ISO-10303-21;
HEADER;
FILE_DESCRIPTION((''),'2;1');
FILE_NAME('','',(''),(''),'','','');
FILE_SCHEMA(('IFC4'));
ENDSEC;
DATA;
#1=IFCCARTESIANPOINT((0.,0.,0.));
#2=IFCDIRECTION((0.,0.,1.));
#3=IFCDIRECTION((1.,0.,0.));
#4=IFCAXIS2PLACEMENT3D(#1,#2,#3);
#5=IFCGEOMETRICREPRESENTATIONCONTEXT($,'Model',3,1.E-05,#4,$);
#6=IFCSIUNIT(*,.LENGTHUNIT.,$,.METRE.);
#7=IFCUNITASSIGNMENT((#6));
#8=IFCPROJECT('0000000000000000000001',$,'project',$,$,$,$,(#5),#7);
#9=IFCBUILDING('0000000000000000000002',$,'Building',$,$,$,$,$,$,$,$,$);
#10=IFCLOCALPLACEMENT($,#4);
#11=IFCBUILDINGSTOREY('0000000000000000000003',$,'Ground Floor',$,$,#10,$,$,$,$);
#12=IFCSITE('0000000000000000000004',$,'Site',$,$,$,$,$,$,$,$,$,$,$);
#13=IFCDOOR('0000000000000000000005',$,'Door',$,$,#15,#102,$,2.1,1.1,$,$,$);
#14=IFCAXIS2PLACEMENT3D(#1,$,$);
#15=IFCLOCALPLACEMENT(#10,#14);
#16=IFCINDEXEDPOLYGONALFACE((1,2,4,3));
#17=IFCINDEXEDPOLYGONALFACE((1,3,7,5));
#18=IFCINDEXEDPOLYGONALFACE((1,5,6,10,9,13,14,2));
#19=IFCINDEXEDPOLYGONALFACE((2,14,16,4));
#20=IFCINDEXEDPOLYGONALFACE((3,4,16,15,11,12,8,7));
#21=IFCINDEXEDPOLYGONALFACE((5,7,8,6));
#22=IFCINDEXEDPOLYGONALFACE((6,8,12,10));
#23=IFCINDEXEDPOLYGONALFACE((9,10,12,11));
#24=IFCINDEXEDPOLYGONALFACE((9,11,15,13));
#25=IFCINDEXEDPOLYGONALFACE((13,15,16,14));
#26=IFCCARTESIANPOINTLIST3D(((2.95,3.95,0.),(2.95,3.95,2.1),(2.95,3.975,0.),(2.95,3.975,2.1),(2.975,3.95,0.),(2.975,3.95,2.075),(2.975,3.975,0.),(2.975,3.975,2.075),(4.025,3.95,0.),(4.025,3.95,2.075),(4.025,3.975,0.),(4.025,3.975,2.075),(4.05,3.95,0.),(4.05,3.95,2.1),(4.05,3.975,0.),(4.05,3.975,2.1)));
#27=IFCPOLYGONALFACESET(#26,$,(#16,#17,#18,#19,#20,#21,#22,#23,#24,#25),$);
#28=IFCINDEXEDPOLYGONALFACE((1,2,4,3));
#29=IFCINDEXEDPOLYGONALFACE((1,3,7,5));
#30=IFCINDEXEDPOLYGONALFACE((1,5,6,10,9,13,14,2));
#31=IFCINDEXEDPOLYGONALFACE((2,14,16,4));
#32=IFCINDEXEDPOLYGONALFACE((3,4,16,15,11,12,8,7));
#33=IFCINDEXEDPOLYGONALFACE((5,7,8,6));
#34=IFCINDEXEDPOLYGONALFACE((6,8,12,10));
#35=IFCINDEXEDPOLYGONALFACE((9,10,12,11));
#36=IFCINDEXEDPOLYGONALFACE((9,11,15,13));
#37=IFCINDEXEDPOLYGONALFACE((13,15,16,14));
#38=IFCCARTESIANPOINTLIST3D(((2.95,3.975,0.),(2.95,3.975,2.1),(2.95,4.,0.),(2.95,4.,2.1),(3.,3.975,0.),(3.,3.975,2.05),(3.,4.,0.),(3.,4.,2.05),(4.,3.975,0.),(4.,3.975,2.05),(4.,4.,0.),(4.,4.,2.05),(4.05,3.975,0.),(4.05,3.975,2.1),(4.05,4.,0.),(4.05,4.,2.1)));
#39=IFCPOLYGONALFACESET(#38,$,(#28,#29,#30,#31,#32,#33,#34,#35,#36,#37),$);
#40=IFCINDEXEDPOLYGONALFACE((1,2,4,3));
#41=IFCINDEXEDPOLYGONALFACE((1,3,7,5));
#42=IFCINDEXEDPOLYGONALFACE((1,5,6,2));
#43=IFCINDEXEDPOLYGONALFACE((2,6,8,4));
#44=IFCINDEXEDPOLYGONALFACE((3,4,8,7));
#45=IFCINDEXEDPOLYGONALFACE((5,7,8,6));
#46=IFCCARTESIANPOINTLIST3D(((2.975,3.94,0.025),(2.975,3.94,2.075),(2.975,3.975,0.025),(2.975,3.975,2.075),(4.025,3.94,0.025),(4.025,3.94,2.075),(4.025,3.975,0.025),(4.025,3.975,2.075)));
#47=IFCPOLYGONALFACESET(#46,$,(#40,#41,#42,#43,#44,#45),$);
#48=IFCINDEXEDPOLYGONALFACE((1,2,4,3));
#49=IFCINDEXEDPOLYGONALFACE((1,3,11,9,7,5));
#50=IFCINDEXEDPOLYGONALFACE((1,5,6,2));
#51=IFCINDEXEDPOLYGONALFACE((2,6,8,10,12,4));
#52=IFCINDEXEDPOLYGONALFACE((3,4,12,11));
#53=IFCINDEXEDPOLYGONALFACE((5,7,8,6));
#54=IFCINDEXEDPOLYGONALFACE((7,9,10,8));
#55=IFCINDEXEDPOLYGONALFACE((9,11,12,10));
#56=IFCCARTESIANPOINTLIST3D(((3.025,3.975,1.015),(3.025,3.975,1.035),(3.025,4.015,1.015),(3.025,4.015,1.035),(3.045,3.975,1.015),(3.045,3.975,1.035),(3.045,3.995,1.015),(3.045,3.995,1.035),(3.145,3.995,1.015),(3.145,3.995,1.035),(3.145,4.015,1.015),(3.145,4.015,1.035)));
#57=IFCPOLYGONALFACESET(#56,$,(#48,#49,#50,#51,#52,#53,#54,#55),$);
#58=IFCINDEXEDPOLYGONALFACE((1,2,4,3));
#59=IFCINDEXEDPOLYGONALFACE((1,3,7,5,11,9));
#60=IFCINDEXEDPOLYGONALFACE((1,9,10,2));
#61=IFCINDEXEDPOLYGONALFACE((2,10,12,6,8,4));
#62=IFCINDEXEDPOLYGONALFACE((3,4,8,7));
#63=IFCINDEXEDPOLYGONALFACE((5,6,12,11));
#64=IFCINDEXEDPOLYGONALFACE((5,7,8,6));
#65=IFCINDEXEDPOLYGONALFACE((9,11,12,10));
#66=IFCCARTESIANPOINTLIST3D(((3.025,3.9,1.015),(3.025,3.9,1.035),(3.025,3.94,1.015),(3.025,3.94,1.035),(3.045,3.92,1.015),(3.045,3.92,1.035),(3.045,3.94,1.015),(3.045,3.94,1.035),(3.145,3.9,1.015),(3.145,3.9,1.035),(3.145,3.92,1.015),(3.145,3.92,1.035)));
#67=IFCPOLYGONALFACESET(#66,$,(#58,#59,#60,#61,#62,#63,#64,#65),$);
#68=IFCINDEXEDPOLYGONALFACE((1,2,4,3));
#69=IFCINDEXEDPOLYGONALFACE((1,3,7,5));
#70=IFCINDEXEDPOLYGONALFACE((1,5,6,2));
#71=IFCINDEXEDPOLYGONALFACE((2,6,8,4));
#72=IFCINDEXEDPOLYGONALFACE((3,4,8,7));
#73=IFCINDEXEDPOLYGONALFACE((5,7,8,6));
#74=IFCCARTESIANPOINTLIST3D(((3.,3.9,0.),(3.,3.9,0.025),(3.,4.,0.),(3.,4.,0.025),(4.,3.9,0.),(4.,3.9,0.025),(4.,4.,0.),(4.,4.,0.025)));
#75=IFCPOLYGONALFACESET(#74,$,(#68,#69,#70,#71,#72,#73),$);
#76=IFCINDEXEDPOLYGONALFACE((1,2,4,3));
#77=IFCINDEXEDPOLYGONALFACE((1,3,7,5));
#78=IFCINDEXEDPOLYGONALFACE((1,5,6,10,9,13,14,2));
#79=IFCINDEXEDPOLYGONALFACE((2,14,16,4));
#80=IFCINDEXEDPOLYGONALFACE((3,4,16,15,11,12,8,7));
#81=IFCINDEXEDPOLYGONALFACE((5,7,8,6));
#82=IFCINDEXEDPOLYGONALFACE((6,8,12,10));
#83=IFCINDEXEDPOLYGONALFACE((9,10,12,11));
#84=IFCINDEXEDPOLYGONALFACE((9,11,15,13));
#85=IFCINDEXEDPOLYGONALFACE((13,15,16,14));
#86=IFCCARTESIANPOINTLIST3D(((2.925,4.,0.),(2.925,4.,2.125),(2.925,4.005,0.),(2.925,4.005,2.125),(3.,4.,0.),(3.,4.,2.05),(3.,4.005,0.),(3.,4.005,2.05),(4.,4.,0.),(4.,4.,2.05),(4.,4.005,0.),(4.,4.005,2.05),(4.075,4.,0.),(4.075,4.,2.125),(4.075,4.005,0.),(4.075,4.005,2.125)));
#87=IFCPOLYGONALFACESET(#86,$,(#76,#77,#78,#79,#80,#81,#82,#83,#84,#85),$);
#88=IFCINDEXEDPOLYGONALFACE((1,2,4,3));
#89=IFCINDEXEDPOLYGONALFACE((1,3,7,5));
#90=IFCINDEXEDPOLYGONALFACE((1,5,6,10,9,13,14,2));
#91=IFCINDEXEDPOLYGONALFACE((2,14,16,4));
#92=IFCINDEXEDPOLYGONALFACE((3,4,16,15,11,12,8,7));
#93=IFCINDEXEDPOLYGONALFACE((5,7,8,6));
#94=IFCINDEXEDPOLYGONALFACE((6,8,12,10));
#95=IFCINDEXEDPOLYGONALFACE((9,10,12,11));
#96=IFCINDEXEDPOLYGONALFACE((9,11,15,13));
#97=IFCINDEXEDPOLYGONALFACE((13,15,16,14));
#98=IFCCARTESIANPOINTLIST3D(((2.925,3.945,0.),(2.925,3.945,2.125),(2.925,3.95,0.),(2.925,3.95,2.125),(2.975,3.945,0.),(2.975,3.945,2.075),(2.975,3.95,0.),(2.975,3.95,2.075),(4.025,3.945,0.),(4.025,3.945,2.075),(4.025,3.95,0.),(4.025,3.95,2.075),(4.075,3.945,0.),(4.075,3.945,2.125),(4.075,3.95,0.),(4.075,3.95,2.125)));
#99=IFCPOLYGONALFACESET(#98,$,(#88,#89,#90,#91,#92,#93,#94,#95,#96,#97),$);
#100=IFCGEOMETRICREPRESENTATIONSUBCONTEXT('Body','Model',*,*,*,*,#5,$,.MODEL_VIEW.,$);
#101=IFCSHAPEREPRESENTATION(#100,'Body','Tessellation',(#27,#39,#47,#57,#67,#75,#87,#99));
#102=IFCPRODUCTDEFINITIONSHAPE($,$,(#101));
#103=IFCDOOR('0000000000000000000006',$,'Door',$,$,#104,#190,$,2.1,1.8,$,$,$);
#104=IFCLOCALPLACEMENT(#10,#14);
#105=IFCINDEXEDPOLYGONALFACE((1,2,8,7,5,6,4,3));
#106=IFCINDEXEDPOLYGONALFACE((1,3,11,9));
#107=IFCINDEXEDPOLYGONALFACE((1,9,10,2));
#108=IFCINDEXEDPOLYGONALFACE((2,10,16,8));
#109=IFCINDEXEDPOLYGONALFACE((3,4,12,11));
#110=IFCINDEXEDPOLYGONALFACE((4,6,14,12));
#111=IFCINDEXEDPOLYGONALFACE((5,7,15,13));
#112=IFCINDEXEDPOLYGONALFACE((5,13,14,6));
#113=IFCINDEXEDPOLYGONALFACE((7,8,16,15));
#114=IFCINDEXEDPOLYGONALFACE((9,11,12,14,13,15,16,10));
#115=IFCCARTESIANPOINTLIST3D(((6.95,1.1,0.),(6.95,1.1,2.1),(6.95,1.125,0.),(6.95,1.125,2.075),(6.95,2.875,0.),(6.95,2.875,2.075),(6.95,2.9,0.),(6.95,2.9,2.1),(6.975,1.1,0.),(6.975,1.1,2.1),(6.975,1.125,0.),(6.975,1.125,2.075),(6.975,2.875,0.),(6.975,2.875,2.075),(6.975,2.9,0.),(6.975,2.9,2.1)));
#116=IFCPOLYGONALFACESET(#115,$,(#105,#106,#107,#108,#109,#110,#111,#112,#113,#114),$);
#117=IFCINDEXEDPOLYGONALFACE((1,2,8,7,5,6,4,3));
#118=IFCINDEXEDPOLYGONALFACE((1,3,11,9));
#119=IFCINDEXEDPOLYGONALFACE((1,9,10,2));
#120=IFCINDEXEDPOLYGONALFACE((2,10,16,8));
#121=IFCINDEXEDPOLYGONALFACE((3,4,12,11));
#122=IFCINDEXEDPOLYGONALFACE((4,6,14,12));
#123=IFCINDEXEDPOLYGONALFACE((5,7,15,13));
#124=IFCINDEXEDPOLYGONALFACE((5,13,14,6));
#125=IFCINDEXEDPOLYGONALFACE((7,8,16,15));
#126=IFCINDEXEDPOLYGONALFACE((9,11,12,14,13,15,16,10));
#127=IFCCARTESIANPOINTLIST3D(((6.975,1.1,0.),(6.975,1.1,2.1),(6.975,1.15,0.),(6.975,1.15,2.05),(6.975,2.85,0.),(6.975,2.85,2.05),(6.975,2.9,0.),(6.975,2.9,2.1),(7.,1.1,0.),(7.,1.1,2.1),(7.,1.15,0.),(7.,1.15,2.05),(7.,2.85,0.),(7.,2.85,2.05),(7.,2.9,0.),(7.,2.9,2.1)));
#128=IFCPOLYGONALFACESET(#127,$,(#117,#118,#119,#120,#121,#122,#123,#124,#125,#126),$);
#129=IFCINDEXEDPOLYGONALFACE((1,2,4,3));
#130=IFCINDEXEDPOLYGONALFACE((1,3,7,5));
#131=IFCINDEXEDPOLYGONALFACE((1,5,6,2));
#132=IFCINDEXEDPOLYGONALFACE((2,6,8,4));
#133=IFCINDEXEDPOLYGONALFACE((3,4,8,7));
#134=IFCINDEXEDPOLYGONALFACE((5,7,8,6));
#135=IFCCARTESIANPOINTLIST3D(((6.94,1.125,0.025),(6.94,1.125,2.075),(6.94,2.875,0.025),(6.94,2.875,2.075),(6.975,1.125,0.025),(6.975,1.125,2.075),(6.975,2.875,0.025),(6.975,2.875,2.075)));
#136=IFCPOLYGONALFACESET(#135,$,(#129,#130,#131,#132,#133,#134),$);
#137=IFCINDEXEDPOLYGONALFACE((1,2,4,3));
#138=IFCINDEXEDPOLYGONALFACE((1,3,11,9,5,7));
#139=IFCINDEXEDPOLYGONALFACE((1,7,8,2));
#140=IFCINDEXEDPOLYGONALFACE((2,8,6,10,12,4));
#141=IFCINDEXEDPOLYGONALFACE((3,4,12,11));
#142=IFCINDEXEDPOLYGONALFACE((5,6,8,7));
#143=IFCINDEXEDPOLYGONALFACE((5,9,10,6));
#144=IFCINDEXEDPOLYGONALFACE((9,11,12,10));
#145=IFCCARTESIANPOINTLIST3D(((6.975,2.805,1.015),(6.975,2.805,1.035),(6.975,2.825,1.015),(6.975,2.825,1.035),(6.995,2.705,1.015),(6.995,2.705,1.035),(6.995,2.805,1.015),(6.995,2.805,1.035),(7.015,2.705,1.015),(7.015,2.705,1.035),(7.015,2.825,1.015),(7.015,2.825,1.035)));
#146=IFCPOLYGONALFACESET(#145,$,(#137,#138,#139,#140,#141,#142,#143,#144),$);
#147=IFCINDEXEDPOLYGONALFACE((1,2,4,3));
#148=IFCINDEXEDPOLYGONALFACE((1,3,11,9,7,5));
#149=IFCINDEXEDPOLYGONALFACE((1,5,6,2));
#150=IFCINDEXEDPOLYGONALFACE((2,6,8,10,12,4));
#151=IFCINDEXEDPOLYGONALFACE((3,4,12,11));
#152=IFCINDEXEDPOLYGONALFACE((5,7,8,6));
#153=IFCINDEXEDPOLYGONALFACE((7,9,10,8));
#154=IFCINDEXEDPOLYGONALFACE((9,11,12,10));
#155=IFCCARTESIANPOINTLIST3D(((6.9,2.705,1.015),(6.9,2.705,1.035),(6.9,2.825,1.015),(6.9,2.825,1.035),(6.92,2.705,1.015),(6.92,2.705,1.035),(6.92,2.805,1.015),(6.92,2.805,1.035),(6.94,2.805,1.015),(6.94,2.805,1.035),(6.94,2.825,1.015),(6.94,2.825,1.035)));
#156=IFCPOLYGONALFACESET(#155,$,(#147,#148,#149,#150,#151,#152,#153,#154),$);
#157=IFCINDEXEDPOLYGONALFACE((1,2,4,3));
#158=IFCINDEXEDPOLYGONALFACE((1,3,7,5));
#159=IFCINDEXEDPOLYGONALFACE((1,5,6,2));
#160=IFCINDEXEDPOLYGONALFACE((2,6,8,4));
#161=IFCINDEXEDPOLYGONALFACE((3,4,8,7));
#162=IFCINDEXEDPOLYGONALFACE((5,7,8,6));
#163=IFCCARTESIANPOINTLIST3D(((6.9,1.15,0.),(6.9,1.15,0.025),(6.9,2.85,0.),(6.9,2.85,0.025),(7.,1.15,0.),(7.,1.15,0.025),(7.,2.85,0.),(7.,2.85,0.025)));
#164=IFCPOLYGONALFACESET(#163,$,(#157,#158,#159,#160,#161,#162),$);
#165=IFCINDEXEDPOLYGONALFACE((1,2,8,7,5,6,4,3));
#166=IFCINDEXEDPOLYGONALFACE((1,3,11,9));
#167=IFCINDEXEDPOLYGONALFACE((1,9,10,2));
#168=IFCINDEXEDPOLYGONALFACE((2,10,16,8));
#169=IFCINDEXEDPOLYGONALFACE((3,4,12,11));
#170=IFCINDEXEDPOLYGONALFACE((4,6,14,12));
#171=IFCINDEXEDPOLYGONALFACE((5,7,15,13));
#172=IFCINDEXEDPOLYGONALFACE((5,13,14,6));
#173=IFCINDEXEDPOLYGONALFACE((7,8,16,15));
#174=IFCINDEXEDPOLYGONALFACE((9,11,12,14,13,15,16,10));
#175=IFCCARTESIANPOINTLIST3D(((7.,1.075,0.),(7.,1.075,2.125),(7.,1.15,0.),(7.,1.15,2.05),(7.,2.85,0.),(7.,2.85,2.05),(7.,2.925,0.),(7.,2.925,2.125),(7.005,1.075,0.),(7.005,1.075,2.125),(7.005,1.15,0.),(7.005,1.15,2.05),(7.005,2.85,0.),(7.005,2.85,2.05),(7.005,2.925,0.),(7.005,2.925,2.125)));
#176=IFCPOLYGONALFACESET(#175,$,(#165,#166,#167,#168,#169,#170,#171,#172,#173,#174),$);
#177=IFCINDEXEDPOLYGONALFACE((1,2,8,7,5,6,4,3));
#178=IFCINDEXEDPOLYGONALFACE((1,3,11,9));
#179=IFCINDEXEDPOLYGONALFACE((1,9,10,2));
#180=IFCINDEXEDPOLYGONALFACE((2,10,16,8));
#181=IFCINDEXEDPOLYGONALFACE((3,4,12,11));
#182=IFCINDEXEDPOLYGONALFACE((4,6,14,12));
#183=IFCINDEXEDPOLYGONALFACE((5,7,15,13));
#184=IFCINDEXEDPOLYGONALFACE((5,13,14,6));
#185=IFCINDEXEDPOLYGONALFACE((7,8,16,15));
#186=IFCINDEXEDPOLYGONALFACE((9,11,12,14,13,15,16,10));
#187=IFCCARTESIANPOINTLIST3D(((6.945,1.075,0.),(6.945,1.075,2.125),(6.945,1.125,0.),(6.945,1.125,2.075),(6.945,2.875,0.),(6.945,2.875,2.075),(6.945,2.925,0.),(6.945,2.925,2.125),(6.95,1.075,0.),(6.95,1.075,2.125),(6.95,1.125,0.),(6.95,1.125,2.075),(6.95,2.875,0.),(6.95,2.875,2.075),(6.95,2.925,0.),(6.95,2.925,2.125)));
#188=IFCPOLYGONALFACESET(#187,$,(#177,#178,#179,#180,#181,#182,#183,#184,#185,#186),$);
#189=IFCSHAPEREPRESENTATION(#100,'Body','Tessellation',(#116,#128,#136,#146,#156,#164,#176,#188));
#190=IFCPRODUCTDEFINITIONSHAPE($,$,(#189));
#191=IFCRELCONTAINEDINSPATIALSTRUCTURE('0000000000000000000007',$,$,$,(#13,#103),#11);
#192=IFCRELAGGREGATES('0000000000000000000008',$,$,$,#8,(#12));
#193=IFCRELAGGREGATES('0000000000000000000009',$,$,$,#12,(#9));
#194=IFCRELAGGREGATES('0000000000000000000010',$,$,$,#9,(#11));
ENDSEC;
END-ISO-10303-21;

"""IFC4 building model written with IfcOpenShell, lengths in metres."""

from ifc_helpers import new_model, si_unit, frame, origin_with_axes, place, context, subcontext, project, spatial, line, indexed_curve, outline, extrude, element, save


model = new_model("IFC4")

# Units and contexts
model_context = context("Model", 3, precision=1e-05, world=origin_with_axes())
body_context = subcontext(model_context, "Body", "Model", "MODEL_VIEW")
ifc_project = project(units=[si_unit("LENGTHUNIT", "METRE")], contexts=[model_context])

# Site, building, storey
site = spatial("IfcSite", under=ifc_project, Name="Site")
building = spatial("IfcBuilding", under=site, Name="Building")
storey_placement = place(None, origin_with_axes())
storey = spatial("IfcBuildingStorey", under=building, at=storey_placement, Name="Ground Floor")

# Doors
door_1_placement = place(storey_placement, frame((4.05, 4.0, 0.0), z_axis=(0.0, 0.0, 1.0), x_axis=(-1.0, 0.0, 0.0)))
element("IfcDoor", 1, at=door_1_placement, inside=storey, Name="Door", OverallHeight=2.1, OverallWidth=1.1, context=body_context, shape_type="SweptSolid", body=[
    extrude(outline(indexed_curve([(0.0, 0.0), (0.0, 2.1), (1.1, 2.1), (1.1, 0.0), (1.075, 0.0), (1.075, 2.075), (0.025, 2.075), (0.025, 0.0)], segments=[line(1, 2, 3, 4, 5, 6, 7, 8, 1)])), frame((0.0, 0.025, 0.0), z_axis=(0.0, -1.0, 0.0), x_axis=(1.0, 0.0, 0.0)), (0.0, 0.0, -1.0), 0.025),
    extrude(outline(indexed_curve([(0.0, 0.0), (0.0, 2.1), (1.1, 2.1), (1.1, 0.0), (1.05, 0.0), (1.05, 2.05), (0.05, 2.05), (0.05, 0.0)], segments=[line(1, 2, 3, 4, 5, 6, 7, 8, 1)])), frame((0.0, 0.0, 0.0), z_axis=(0.0, -1.0, 0.0), x_axis=(1.0, 0.0, 0.0)), (0.0, 0.0, -1.0), 0.025),
    extrude(outline(indexed_curve([(0.0, 0.0), (1.05, 0.0), (1.05, 0.035), (0.0, 0.035)], segments=[line(1, 2, 3, 4, 1)])), frame((0.025, 0.025, 0.025), z_axis=(0.0, 0.0, 1.0), x_axis=(1.0, 0.0, 0.0)), (0.0, 0.0, 1.0), 2.05),
    extrude(outline(indexed_curve([(0.0, 0.0), (0.0, -0.04), (-0.12, -0.04), (-0.12, -0.02), (-0.02, -0.02), (-0.02, 0.0)], segments=[line(1, 2, 3, 4, 5, 6, 1)])), frame((1.025, 0.025, 1.015), z_axis=(0.0, 0.0, 1.0), x_axis=(1.0, 0.0, 0.0)), (0.0, 0.0, 1.0), 0.02),
    extrude(outline(indexed_curve([(0.0, 0.0), (0.0, 0.04), (-0.12, 0.04), (-0.12, 0.02), (-0.02, 0.02), (-0.02, 0.0)], segments=[line(1, 2, 3, 4, 5, 6, 1)])), frame((1.025, 0.06, 1.015), z_axis=(0.0, 0.0, 1.0), x_axis=(1.0, 0.0, 0.0)), (0.0, 0.0, 1.0), 0.02),
    extrude(outline(indexed_curve([(0.0, 0.0), (1.0, 0.0), (1.0, 0.1), (0.0, 0.1)], segments=[line(1, 2, 3, 4, 1)])), frame((0.05, 0.0, 0.0), z_axis=(0.0, 0.0, 1.0), x_axis=(1.0, 0.0, 0.0)), (0.0, 0.0, 1.0), 0.025),
    extrude(outline(indexed_curve([(0.0, 0.0), (0.0, 2.125), (1.15, 2.125), (1.15, 0.0), (1.075, 0.0), (1.075, 2.05), (0.075, 2.05), (0.075, 0.0)], segments=[line(1, 2, 3, 4, 5, 6, 7, 8, 1)])), frame((-0.025, -0.005, 0.0), z_axis=(0.0, -1.0, 0.0), x_axis=(1.0, 0.0, 0.0)), (0.0, 0.0, -1.0), 0.005),
    extrude(outline(indexed_curve([(0.0, 0.0), (0.0, 2.125), (1.15, 2.125), (1.15, 0.0), (1.1, 0.0), (1.1, 2.075), (0.05, 2.075), (0.05, 0.0)], segments=[line(1, 2, 3, 4, 5, 6, 7, 8, 1)])), frame((-0.025, 0.05, 0.0), z_axis=(0.0, -1.0, 0.0), x_axis=(1.0, 0.0, 0.0)), (0.0, 0.0, -1.0), 0.005),
])
door_2_placement = place(storey_placement, frame((7.0, 1.1, 0.0), z_axis=(0.0, 0.0, 1.0), x_axis=(0.0, 1.0, 0.0)))
element("IfcDoor", 2, at=door_2_placement, inside=storey, Name="Door", OverallHeight=2.1, OverallWidth=1.8, context=body_context, shape_type="SweptSolid", body=[
    extrude(outline(indexed_curve([(0.0, 0.0), (0.0, 2.1), (1.8, 2.1), (1.8, 0.0), (1.775, 0.0), (1.775, 2.075), (0.025, 2.075), (0.025, 0.0)], segments=[line(1, 2, 3, 4, 5, 6, 7, 8, 1)])), frame((0.0, 0.025, 0.0), z_axis=(0.0, -1.0, 0.0), x_axis=(1.0, 0.0, 0.0)), (0.0, 0.0, -1.0), 0.025),
    extrude(outline(indexed_curve([(0.0, 0.0), (0.0, 2.1), (1.8, 2.1), (1.8, 0.0), (1.75, 0.0), (1.75, 2.05), (0.05, 2.05), (0.05, 0.0)], segments=[line(1, 2, 3, 4, 5, 6, 7, 8, 1)])), frame((0.0, 0.0, 0.0), z_axis=(0.0, -1.0, 0.0), x_axis=(1.0, 0.0, 0.0)), (0.0, 0.0, -1.0), 0.025),
    extrude(outline(indexed_curve([(0.0, 0.0), (1.75, 0.0), (1.75, 0.035), (0.0, 0.035)], segments=[line(1, 2, 3, 4, 1)])), frame((0.025, 0.025, 0.025), z_axis=(0.0, 0.0, 1.0), x_axis=(1.0, 0.0, 0.0)), (0.0, 0.0, 1.0), 2.05),
    extrude(outline(indexed_curve([(0.0, 0.0), (0.0, -0.04), (-0.12, -0.04), (-0.12, -0.02), (-0.02, -0.02), (-0.02, 0.0)], segments=[line(1, 2, 3, 4, 5, 6, 1)])), frame((1.725, 0.025, 1.015), z_axis=(0.0, 0.0, 1.0), x_axis=(1.0, 0.0, 0.0)), (0.0, 0.0, 1.0), 0.02),
    extrude(outline(indexed_curve([(0.0, 0.0), (0.0, 0.04), (-0.12, 0.04), (-0.12, 0.02), (-0.02, 0.02), (-0.02, 0.0)], segments=[line(1, 2, 3, 4, 5, 6, 1)])), frame((1.725, 0.06, 1.015), z_axis=(0.0, 0.0, 1.0), x_axis=(1.0, 0.0, 0.0)), (0.0, 0.0, 1.0), 0.02),
    extrude(outline(indexed_curve([(0.0, 0.0), (1.7, 0.0), (1.7, 0.1), (0.0, 0.1)], segments=[line(1, 2, 3, 4, 1)])), frame((0.05, 0.0, 0.0), z_axis=(0.0, 0.0, 1.0), x_axis=(1.0, 0.0, 0.0)), (0.0, 0.0, 1.0), 0.025),
    extrude(outline(indexed_curve([(0.0, 0.0), (0.0, 2.125), (1.85, 2.125), (1.85, 0.0), (1.775, 0.0), (1.775, 2.05), (0.075, 2.05), (0.075, 0.0)], segments=[line(1, 2, 3, 4, 5, 6, 7, 8, 1)])), frame((-0.025, -0.005, 0.0), z_axis=(0.0, -1.0, 0.0), x_axis=(1.0, 0.0, 0.0)), (0.0, 0.0, -1.0), 0.005),
    extrude(outline(indexed_curve([(0.0, 0.0), (0.0, 2.125), (1.85, 2.125), (1.85, 0.0), (1.8, 0.0), (1.8, 2.075), (0.05, 2.075), (0.05, 0.0)], segments=[line(1, 2, 3, 4, 5, 6, 7, 8, 1)])), frame((-0.025, 0.05, 0.0), z_axis=(0.0, -1.0, 0.0), x_axis=(1.0, 0.0, 0.0)), (0.0, 0.0, -1.0), 0.005),
])

save(model, "model.ifc")
